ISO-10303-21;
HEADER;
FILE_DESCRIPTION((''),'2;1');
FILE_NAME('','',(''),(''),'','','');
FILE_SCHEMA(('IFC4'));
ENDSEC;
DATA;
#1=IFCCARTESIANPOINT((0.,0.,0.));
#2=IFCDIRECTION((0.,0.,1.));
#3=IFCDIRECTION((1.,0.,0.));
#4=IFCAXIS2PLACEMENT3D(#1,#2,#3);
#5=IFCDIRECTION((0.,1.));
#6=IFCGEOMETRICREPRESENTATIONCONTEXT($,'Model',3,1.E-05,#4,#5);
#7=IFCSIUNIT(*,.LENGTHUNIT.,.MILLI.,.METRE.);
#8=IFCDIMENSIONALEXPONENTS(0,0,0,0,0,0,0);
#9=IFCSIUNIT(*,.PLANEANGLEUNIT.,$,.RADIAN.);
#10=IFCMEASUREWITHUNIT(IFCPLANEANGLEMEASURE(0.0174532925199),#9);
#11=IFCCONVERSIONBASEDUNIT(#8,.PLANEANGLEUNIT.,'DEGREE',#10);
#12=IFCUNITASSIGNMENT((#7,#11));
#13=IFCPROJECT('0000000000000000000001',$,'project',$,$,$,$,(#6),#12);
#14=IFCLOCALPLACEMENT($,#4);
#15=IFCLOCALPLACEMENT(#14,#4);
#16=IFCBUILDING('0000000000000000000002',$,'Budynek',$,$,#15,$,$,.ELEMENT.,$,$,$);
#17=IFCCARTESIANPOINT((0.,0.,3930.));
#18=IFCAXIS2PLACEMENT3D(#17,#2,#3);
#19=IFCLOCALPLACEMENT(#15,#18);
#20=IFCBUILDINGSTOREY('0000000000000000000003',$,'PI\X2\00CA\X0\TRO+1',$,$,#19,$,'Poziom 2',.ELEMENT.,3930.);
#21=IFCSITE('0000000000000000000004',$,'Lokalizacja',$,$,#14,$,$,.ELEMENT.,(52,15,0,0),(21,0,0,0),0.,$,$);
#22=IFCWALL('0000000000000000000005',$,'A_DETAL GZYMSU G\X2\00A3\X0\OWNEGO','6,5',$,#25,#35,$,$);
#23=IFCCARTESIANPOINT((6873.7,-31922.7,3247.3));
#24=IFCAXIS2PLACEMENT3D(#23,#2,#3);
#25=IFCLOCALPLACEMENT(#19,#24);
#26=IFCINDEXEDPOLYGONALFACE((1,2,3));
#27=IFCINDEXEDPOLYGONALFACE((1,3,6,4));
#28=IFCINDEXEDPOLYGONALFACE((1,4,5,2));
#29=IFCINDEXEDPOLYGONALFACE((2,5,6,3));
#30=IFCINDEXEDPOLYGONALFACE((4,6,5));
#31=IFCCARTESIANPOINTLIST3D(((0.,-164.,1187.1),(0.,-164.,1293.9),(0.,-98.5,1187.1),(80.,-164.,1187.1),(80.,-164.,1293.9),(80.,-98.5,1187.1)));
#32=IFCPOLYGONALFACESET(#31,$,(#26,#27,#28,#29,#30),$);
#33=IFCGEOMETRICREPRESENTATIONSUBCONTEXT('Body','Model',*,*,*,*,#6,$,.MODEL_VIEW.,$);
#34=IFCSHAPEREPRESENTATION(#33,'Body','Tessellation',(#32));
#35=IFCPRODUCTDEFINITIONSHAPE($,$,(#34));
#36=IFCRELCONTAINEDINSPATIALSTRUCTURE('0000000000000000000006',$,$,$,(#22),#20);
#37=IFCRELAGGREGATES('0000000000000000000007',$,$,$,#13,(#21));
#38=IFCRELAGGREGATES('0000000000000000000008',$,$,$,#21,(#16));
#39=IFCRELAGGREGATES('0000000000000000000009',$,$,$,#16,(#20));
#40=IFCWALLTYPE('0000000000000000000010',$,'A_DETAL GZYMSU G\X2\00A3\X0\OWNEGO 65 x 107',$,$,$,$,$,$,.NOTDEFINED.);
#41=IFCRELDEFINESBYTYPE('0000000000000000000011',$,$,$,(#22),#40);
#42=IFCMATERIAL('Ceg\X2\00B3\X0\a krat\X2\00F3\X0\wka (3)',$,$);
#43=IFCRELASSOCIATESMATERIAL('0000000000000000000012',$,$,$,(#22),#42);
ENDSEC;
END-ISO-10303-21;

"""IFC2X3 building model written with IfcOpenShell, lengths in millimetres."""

from ifc_helpers import new_model, entity, si_unit, converted_unit, direction, frame, origin_with_axes, place, context, subcontext, project, spatial, polyline, outline, extrude, material, type_object, element, save


model = new_model("IFC2X3")

# Units and contexts
model_context = context("Model", 3, precision=1e-05, world=origin_with_axes(), true_north=direction((0.0, 1.0)))
body_context = subcontext(model_context, "Body", "Model", "MODEL_VIEW")
ifc_project = project(units=[si_unit("LENGTHUNIT", "METRE", prefix="MILLI"), converted_unit("PLANEANGLEUNIT", "DEGREE", entity("IfcPlaneAngleMeasure", 0.0174532925199), si_unit("PLANEANGLEUNIT", "RADIAN"), dimensions=[0, 0, 0, 0, 0, 0, 0])], contexts=[model_context])

# Site, building, storey
site_placement = place(None, origin_with_axes())
site = spatial("IfcSite", under=ifc_project, at=site_placement, Name="Lokalizacja", CompositionType="ELEMENT", RefLatitude=(52, 15, 0, 0), RefLongitude=(21, 0, 0, 0), RefElevation=0.0)
building_placement = place(site_placement, origin_with_axes())
building = spatial("IfcBuilding", under=site, at=building_placement, Name="Budynek", CompositionType="ELEMENT")
storey_placement = place(building_placement, frame((0.0, 0.0, 3930.0), z_axis=(0.0, 0.0, 1.0), x_axis=(1.0, 0.0, 0.0)))
storey = spatial("IfcBuildingStorey", under=building, at=storey_placement, Name="PIÊTRO+1", LongName="Poziom 2", CompositionType="ELEMENT", Elevation=3930.0)

# Wall
ifc_material_1 = material(Name="Ceg³a kratówka (3)")
wall_type = type_object("IfcWallType", Name="A_DETAL GZYMSU G£OWNEGO 65 x 107", PredefinedType="NOTDEFINED")
for number, where, z_axis, x_axis, name in (
    (1, (6873.7, -31922.7, 3247.3), (0.0, 0.0, 1.0), (1.0, 0.0, 0.0), "A_DETAL GZYMSU G£OWNEGO"),
):
    element("IfcWall", number, at=place(storey_placement, frame(where, z_axis=z_axis, x_axis=x_axis)), inside=storey, type_object=wall_type, material=ifc_material_1, Name=name, Description="6,5", context=body_context, shape_type="SweptSolid", body=[
        extrude(outline(polyline([(-164.0, 1293.9), (-164.0, 1187.1), (-98.5, 1187.1), (-164.0, 1293.9)])), frame((0.0, 0.0, 0.0), z_axis=(1.0, 0.0, 0.0), x_axis=(0.0, 1.0, 0.0)), (0.0, 0.0, 1.0), 80.0),
    ])

save(model, "model.ifc")
